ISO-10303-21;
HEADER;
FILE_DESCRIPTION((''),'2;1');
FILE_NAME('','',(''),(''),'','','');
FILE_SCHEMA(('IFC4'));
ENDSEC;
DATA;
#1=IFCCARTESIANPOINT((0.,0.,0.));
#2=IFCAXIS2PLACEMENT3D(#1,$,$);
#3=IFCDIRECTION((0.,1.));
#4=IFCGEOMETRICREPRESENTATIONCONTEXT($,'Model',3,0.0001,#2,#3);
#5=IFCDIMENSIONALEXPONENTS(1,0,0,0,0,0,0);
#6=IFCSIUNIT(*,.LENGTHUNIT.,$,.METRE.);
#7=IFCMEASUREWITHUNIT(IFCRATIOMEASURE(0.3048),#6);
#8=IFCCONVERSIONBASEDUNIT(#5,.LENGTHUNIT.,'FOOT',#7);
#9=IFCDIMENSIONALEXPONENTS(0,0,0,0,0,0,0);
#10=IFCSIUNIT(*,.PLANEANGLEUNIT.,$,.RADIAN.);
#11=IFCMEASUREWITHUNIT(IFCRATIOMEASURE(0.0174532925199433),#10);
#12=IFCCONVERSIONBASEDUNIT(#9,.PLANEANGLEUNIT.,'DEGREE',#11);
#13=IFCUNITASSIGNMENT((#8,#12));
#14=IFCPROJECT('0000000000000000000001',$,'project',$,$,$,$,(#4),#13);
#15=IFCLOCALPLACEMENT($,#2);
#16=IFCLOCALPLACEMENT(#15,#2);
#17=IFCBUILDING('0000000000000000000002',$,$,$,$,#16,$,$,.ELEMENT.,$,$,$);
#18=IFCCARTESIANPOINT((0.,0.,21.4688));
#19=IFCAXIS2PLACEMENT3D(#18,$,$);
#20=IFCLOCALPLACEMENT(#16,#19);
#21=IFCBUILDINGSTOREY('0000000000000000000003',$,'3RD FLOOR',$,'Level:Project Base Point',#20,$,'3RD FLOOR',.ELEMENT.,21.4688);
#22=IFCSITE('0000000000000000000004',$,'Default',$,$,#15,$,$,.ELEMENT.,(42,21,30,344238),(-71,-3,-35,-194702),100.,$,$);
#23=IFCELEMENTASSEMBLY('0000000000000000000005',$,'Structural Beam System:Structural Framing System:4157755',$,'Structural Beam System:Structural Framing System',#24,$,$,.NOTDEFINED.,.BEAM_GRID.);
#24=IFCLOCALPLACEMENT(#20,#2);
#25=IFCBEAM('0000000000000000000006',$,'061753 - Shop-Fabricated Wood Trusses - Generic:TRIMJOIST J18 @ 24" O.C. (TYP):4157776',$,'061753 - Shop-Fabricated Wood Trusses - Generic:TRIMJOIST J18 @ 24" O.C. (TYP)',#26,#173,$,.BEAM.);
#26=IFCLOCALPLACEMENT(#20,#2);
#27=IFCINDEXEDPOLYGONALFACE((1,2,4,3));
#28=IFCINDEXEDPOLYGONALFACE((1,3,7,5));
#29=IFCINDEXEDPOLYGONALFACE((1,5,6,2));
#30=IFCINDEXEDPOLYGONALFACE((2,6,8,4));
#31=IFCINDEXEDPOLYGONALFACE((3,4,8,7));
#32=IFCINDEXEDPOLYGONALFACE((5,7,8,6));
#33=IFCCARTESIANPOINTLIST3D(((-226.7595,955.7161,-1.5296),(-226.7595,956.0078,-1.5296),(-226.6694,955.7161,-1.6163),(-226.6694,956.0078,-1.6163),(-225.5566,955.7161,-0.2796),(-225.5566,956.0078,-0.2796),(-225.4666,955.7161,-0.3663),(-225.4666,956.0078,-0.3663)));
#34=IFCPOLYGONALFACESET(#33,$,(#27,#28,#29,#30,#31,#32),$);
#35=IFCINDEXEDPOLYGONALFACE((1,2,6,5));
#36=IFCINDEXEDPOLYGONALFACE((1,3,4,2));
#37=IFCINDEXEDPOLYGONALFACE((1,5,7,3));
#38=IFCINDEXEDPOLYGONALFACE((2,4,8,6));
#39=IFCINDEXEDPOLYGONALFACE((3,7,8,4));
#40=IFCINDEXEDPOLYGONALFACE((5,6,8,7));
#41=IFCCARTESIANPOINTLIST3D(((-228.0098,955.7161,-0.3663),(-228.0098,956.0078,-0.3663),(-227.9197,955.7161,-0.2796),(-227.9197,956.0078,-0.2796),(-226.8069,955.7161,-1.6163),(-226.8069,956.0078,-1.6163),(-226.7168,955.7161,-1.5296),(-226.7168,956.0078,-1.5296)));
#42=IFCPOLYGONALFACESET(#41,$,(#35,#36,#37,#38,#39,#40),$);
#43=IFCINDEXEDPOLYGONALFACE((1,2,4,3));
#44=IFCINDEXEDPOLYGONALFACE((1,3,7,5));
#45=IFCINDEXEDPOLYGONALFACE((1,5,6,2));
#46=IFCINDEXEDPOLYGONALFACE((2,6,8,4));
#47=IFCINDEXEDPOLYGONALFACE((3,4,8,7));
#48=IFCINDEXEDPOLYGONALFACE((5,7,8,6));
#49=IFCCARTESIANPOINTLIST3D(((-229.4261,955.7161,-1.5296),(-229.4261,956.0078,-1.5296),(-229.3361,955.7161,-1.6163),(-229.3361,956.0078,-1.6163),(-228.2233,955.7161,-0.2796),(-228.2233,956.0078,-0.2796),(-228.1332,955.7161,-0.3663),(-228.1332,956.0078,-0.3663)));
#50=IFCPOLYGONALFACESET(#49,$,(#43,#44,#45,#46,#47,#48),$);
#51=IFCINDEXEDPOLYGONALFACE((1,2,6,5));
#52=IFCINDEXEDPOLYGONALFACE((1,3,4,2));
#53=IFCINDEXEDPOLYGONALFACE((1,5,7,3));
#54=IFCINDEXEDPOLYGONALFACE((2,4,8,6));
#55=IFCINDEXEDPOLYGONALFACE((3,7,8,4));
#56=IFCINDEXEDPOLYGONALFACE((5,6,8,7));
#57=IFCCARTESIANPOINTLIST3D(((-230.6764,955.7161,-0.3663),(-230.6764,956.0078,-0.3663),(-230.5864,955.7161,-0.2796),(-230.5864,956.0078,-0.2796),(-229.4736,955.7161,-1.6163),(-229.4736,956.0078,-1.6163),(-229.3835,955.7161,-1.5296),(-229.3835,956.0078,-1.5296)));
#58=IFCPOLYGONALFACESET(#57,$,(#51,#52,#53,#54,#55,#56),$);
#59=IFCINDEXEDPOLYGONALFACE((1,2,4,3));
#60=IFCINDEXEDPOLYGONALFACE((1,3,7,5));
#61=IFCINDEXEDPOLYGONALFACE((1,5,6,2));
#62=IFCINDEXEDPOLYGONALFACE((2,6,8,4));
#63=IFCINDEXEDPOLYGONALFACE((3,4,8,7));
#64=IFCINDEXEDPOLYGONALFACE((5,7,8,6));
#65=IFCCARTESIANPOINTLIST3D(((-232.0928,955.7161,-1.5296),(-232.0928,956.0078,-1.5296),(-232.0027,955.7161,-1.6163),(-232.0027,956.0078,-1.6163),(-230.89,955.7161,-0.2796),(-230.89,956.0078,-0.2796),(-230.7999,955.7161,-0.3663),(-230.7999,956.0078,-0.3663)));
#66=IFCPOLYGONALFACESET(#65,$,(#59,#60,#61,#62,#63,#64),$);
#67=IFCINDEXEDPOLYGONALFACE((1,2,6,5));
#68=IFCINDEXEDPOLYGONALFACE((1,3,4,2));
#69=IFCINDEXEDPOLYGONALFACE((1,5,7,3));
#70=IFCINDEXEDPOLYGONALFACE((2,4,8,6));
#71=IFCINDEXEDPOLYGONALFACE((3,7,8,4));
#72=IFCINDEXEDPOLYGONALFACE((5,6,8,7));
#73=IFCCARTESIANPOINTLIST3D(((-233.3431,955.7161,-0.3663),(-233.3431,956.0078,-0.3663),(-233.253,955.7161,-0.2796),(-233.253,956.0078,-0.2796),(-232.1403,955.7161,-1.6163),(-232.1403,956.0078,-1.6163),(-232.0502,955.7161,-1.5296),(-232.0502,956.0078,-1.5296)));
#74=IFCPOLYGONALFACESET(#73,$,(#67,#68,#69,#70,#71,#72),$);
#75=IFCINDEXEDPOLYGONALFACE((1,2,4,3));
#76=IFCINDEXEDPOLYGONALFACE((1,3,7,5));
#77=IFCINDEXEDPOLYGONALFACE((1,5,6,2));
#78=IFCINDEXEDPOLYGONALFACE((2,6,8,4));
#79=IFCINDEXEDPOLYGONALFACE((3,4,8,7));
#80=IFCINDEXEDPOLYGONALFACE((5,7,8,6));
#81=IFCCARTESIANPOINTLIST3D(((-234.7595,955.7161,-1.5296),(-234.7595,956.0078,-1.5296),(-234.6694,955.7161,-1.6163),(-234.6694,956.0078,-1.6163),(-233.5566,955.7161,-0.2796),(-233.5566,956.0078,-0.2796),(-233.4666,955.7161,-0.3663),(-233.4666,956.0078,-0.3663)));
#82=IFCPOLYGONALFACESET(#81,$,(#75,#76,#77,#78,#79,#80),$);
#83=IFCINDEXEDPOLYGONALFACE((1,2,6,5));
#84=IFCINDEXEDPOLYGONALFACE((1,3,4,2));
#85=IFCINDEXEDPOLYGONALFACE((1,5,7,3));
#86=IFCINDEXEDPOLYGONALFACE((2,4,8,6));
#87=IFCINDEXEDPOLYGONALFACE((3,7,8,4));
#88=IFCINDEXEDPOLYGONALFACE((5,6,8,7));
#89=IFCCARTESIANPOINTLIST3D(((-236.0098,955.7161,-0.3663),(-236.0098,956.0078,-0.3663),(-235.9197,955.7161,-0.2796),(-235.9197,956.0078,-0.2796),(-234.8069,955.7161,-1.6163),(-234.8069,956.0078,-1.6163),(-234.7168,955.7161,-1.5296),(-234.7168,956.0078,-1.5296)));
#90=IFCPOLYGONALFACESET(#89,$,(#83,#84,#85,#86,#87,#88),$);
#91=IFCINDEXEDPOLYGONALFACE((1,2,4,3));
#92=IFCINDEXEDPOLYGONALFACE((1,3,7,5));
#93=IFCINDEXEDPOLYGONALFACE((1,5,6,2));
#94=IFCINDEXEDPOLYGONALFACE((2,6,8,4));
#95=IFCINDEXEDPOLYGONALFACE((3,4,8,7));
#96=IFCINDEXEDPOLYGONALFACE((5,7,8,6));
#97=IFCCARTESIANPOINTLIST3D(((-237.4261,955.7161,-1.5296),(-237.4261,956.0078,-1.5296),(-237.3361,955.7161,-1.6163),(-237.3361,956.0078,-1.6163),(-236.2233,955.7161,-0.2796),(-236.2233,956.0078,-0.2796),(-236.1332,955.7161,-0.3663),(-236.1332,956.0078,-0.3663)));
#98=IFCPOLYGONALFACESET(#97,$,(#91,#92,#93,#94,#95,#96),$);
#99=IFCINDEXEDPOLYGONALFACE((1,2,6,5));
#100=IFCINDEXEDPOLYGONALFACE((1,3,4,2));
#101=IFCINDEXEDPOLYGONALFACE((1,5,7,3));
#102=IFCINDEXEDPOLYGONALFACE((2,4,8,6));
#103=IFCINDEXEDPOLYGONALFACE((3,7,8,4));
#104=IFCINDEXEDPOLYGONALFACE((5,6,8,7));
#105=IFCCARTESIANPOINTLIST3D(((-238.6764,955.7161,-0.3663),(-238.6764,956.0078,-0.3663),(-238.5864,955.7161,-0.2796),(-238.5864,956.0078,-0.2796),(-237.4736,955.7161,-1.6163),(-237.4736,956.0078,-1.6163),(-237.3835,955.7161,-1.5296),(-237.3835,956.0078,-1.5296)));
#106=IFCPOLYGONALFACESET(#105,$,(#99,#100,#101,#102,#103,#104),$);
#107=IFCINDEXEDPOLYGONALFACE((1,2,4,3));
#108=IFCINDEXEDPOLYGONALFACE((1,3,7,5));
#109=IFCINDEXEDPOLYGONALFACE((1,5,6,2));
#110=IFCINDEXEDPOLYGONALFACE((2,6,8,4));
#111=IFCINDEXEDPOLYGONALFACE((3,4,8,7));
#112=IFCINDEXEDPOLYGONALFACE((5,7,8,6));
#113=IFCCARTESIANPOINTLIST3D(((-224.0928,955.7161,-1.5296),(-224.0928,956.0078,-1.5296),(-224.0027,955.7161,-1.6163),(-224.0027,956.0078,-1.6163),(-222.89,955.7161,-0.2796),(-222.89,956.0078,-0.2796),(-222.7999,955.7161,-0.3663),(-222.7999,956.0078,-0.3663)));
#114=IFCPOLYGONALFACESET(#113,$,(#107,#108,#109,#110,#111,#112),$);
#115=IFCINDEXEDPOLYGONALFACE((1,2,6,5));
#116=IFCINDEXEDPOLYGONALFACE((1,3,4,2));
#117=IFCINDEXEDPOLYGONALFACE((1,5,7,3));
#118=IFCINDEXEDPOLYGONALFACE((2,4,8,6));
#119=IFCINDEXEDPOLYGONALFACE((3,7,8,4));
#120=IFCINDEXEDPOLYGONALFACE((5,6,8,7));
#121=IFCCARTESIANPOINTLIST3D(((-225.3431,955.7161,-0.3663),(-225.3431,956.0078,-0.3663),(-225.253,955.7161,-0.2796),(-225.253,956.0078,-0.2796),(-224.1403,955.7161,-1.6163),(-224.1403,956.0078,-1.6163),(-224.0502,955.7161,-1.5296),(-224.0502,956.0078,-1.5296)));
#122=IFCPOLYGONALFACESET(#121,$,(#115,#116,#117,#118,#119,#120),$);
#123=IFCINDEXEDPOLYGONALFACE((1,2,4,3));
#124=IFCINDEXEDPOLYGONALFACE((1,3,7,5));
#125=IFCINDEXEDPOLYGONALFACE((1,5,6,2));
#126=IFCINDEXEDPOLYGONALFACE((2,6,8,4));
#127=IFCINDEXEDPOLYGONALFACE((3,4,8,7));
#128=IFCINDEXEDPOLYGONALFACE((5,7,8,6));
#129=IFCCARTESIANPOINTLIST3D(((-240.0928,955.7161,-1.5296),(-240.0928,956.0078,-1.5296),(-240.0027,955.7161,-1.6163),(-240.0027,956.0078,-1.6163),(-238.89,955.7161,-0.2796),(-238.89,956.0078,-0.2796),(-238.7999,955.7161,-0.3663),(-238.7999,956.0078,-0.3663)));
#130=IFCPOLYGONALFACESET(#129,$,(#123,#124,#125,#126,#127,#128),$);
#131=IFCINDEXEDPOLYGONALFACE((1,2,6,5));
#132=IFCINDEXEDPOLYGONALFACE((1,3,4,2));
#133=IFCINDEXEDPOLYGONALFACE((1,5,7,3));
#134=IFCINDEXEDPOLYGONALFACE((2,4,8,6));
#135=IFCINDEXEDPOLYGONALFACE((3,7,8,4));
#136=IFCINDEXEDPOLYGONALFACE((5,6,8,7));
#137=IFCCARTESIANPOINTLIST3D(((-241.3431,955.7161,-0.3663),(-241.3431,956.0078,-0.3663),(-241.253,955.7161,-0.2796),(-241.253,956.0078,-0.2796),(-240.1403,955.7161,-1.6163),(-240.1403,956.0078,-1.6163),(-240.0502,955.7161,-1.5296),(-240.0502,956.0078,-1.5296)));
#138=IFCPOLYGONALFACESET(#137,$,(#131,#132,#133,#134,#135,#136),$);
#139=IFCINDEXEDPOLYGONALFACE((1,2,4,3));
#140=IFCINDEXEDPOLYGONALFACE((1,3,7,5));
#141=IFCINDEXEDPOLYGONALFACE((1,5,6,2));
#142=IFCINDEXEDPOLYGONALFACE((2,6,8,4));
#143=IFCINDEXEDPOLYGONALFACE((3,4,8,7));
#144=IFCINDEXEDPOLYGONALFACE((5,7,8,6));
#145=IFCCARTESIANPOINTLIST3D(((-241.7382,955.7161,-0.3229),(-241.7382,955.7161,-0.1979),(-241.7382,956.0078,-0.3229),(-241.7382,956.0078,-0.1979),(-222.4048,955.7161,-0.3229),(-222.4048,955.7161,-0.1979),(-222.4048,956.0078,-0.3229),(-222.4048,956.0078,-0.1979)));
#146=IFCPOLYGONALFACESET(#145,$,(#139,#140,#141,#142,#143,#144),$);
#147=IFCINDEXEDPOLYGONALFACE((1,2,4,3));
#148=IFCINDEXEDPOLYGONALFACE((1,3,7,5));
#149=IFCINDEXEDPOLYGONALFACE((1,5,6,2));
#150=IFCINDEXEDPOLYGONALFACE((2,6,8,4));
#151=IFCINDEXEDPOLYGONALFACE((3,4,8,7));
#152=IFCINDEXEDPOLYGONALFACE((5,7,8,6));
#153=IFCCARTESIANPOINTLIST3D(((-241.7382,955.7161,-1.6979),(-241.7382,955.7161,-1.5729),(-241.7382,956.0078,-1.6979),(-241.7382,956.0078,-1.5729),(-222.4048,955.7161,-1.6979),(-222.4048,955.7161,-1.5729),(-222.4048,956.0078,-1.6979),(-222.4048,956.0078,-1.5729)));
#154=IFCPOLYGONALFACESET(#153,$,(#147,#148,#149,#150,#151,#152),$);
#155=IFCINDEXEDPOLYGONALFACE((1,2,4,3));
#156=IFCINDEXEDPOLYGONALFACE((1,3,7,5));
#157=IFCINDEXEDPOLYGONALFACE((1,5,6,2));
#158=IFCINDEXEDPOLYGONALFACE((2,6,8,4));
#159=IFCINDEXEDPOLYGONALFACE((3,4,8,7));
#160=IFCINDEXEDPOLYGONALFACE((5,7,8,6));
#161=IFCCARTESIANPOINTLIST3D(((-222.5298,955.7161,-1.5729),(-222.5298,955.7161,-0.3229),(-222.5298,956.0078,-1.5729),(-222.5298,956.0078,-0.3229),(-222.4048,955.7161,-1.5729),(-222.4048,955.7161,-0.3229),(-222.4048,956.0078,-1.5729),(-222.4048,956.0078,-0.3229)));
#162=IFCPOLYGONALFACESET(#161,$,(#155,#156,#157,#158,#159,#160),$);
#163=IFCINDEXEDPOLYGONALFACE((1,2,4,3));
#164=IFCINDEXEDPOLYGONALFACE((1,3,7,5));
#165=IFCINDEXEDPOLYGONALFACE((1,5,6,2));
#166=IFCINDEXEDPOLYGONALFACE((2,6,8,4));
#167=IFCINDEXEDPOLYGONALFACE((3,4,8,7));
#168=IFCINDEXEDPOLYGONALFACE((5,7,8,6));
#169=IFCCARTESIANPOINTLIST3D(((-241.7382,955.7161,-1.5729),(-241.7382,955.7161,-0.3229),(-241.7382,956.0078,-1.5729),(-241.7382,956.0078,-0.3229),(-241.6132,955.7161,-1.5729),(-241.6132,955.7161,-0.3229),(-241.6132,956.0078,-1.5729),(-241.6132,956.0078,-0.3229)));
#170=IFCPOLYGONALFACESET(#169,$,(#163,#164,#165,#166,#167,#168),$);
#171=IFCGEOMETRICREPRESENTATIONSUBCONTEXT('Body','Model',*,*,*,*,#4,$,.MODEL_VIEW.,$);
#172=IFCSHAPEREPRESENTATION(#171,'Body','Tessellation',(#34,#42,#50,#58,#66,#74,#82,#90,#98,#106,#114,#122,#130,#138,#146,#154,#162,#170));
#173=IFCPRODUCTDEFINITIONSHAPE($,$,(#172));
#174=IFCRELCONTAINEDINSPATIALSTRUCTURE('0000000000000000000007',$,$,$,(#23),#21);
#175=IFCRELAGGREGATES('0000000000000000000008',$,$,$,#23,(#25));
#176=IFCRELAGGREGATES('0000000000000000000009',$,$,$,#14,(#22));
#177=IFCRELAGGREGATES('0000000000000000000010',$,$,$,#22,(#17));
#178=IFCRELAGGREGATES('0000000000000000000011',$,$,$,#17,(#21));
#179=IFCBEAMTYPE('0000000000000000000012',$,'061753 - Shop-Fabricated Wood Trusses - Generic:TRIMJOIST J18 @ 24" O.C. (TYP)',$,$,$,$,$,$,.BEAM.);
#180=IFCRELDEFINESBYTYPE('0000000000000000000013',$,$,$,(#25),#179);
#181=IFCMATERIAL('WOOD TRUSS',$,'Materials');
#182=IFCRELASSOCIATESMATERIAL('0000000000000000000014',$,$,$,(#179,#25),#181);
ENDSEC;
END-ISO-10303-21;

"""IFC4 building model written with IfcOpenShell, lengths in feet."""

from ifc_helpers import new_model, entity, si_unit, converted_unit, direction, frame, frame_2d, origin, origin_2d_with_axis, place, context, subcontext, project, spatial, rectangle, extrude, source, transform, mapped, material, material_profile, profile_set, profile_usage, type_object, type_shapes, element, aggregate, save


model = new_model("IFC4")

# Units and contexts
model_context = context("Model", 3, precision=0.0001, world=origin(), true_north=direction((0.0, 1.0)))
body_context = subcontext(model_context, "Body", "Model", "MODEL_VIEW")
ifc_project = project(units=[converted_unit("LENGTHUNIT", "FOOT", entity("IfcRatioMeasure", 0.3048), si_unit("LENGTHUNIT", "METRE"), dimensions=[1, 0, 0, 0, 0, 0, 0]), converted_unit("PLANEANGLEUNIT", "DEGREE", entity("IfcRatioMeasure", 0.0174532925199433), si_unit("PLANEANGLEUNIT", "RADIAN"), dimensions=[0, 0, 0, 0, 0, 0, 0])], contexts=[model_context])

# Site, building, storey
site_placement = place(None, origin())
site = spatial("IfcSite", under=ifc_project, at=site_placement, Name="Default", CompositionType="ELEMENT", RefLatitude=(42, 21, 30, 344238), RefLongitude=(-71, -3, -35, -194702), RefElevation=100.0)
building_placement = place(site_placement, origin())
building = spatial("IfcBuilding", under=site, at=building_placement, CompositionType="ELEMENT")
storey_placement = place(building_placement, frame((0.0, 0.0, 21.4688)))
storey = spatial("IfcBuildingStorey", under=building, at=storey_placement, Name="3RD FLOOR", ObjectType="Level:Project Base Point", LongName="3RD FLOOR", CompositionType="ELEMENT", Elevation=21.4688)

# Element assembly, beam
assembly_1_placement = place(storey_placement, origin())
assembly_1 = element("IfcElementAssembly", 1, at=assembly_1_placement, inside=storey, Name="Structural Beam System:Structural Framing System:4157755", ObjectType="Structural Beam System:Structural Framing System", AssemblyPlace="NOTDEFINED", PredefinedType="BEAM_GRID")
ifc_material_1 = material(Name="WOOD TRUSS", Category="Materials")
ifc_material_profile_1 = material_profile(ifc_material_1, rectangle(XDim=1.7347, YDim=0.125, at=frame_2d((0.0, 0.0), x_axis=(1.0, 0.0))), Name="TRIMJOIST J18 @ 24\" O.C. (TYP)")
ifc_material_profile_2 = material_profile(ifc_material_1, rectangle(XDim=1.7347, YDim=0.125, at=frame_2d((0.0, 0.0), x_axis=(1.0, 0.0))), Name="TRIMJOIST J18 @ 24\" O.C. (TYP)")
ifc_material_profile_3 = material_profile(ifc_material_1, rectangle(XDim=1.7347, YDim=0.125, at=frame_2d((0.0, 0.0), x_axis=(1.0, 0.0))), Name="TRIMJOIST J18 @ 24\" O.C. (TYP)")
ifc_material_profile_4 = material_profile(ifc_material_1, rectangle(XDim=1.7347, YDim=0.125, at=frame_2d((0.0, 0.0), x_axis=(1.0, 0.0))), Name="TRIMJOIST J18 @ 24\" O.C. (TYP)")
ifc_material_profile_5 = material_profile(ifc_material_1, rectangle(XDim=1.7347, YDim=0.125, at=frame_2d((0.0, 0.0), x_axis=(1.0, 0.0))), Name="TRIMJOIST J18 @ 24\" O.C. (TYP)")
ifc_material_profile_6 = material_profile(ifc_material_1, rectangle(XDim=1.7347, YDim=0.125, at=frame_2d((0.0, 0.0), x_axis=(1.0, 0.0))), Name="TRIMJOIST J18 @ 24\" O.C. (TYP)")
ifc_material_profile_7 = material_profile(ifc_material_1, rectangle(XDim=1.7347, YDim=0.125, at=frame_2d((0.0, 0.0), x_axis=(1.0, 0.0))), Name="TRIMJOIST J18 @ 24\" O.C. (TYP)")
ifc_material_profile_8 = material_profile(ifc_material_1, rectangle(XDim=1.7347, YDim=0.125, at=frame_2d((0.0, 0.0), x_axis=(1.0, 0.0))), Name="TRIMJOIST J18 @ 24\" O.C. (TYP)")
ifc_material_profile_9 = material_profile(ifc_material_1, rectangle(XDim=1.7347, YDim=0.125, at=frame_2d((0.0, 0.0), x_axis=(1.0, 0.0))), Name="TRIMJOIST J18 @ 24\" O.C. (TYP)")
ifc_material_profile_10 = material_profile(ifc_material_1, rectangle(XDim=1.7347, YDim=0.125, at=origin_2d_with_axis()), Name="TRIMJOIST J18 @ 24\" O.C. (TYP)")
ifc_material_profile_11 = material_profile(ifc_material_1, rectangle(XDim=0.125, YDim=0.2917, at=origin_2d_with_axis()), Name="TRIMJOIST J18 @ 24\" O.C. (TYP)")
ifc_material_profile_12 = material_profile(ifc_material_1, rectangle(XDim=0.125, YDim=0.2917, at=origin_2d_with_axis()), Name="TRIMJOIST J18 @ 24\" O.C. (TYP)")
ifc_material_profile_13 = material_profile(ifc_material_1, rectangle(XDim=1.25, YDim=0.2917, at=origin_2d_with_axis()), Name="TRIMJOIST J18 @ 24\" O.C. (TYP)")
ifc_material_profile_14 = material_profile(ifc_material_1, rectangle(XDim=1.25, YDim=0.2917, at=origin_2d_with_axis()), Name="TRIMJOIST J18 @ 24\" O.C. (TYP)")
ifc_profile_set_1 = profile_set([ifc_material_profile_1, ifc_material_profile_2, ifc_material_profile_3, ifc_material_profile_4, ifc_material_profile_5, ifc_material_profile_6, ifc_material_profile_7, ifc_material_profile_8, ifc_material_profile_9, ifc_material_profile_10, ifc_material_profile_11, ifc_material_profile_12, ifc_material_profile_13, ifc_material_profile_14], Name="TRIMJOIST J18 @ 24\" O.C. (TYP)")
ifc_profile_usage_1 = profile_usage(ifc_profile_set_1, cardinal=8)
beam_type_1 = type_object("IfcBeamType", Name="061753 - Shop-Fabricated Wood Trusses - Generic:TRIMJOIST J18 @ 24\" O.C. (TYP)", PredefinedType="BEAM", material=ifc_profile_set_1)
shared_shape_1 = source(origin(), body_context, "Body", "SweptSolid", [
    extrude(rectangle(XDim=1.7347, YDim=0.125, at=frame_2d((0.0, 0.0), x_axis=(1.0, 0.0))), frame((5.9585, -0.1458, 0.0), z_axis=(0.0, 1.0, 0.0), x_axis=(0.693383, 0.0, 0.720569)), (0.0, 0.0, 1.0), 0.2917),
    extrude(rectangle(XDim=1.7347, YDim=0.125, at=origin_2d_with_axis()), frame((4.7082, -0.1458, 0.0), z_axis=(0.0, 1.0, 0.0), x_axis=(0.693383, 0.0, -0.720569)), (0.0, 0.0, 1.0), 0.2917),
    extrude(rectangle(XDim=1.7347, YDim=0.125, at=frame_2d((0.0, 0.0), x_axis=(1.0, 0.0))), frame((3.2918, -0.1458, 0.0), z_axis=(0.0, 1.0, 0.0), x_axis=(0.693383, 0.0, 0.720569)), (0.0, 0.0, 1.0), 0.2917),
    extrude(rectangle(XDim=1.7347, YDim=0.125, at=frame_2d((0.0, 0.0), x_axis=(1.0, 0.0))), frame((2.0415, -0.1458, 0.0), z_axis=(0.0, 1.0, 0.0), x_axis=(0.693383, 0.0, -0.720569)), (0.0, 0.0, 1.0), 0.2917),
    extrude(rectangle(XDim=1.7347, YDim=0.125, at=frame_2d((0.0, 0.0), x_axis=(1.0, 0.0))), frame((0.6251, -0.1458, 0.0), z_axis=(0.0, 1.0, 0.0), x_axis=(0.693383, 0.0, 0.720569)), (0.0, 0.0, 1.0), 0.2917),
    extrude(rectangle(XDim=1.7347, YDim=0.125, at=frame_2d((0.0, 0.0), x_axis=(1.0, 0.0))), frame((-0.6251, -0.1458, 0.0), z_axis=(0.0, 1.0, 0.0), x_axis=(0.693383, 0.0, -0.720569)), (0.0, 0.0, 1.0), 0.2917),
    extrude(rectangle(XDim=1.7347, YDim=0.125, at=frame_2d((0.0, 0.0), x_axis=(1.0, 0.0))), frame((-2.0415, -0.1458, 0.0), z_axis=(0.0, 1.0, 0.0), x_axis=(0.693383, 0.0, 0.720569)), (0.0, 0.0, 1.0), 0.2917),
    extrude(rectangle(XDim=1.7347, YDim=0.125, at=origin_2d_with_axis()), frame((-3.2918, -0.1458, 0.0), z_axis=(0.0, 1.0, 0.0), x_axis=(0.693383, 0.0, -0.720569)), (0.0, 0.0, 1.0), 0.2917),
    extrude(rectangle(XDim=1.7347, YDim=0.125, at=frame_2d((0.0, 0.0), x_axis=(1.0, 0.0))), frame((-4.7082, -0.1458, 0.0), z_axis=(0.0, 1.0, 0.0), x_axis=(0.693383, 0.0, 0.720569)), (0.0, 0.0, 1.0), 0.2917),
    extrude(rectangle(XDim=1.7347, YDim=0.125, at=frame_2d((0.0, 0.0), x_axis=(1.0, 0.0))), frame((-5.9585, -0.1458, 0.0), z_axis=(0.0, 1.0, 0.0), x_axis=(0.693383, 0.0, -0.720569)), (0.0, 0.0, 1.0), 0.2917),
    extrude(rectangle(XDim=1.7347, YDim=0.125, at=frame_2d((0.0, 0.0), x_axis=(1.0, 0.0))), frame((8.6251, -0.1458, 0.0), z_axis=(0.0, 1.0, 0.0), x_axis=(0.693383, 0.0, 0.720569)), (0.0, 0.0, 1.0), 0.2917),
    extrude(rectangle(XDim=1.7347, YDim=0.125, at=origin_2d_with_axis()), frame((7.3749, -0.1458, 0.0), z_axis=(0.0, 1.0, 0.0), x_axis=(0.693383, 0.0, -0.720569)), (0.0, 0.0, 1.0), 0.2917),
    extrude(rectangle(XDim=1.7347, YDim=0.125, at=frame_2d((0.0, 0.0), x_axis=(1.0, 0.0))), frame((-7.3749, -0.1458, 0.0), z_axis=(0.0, 1.0, 0.0), x_axis=(0.693383, 0.0, 0.720569)), (0.0, 0.0, 1.0), 0.2917),
    extrude(rectangle(XDim=1.7347, YDim=0.125, at=origin_2d_with_axis()), frame((-8.6251, -0.1458, 0.0), z_axis=(0.0, 1.0, 0.0), x_axis=(0.693383, 0.0, -0.720569)), (0.0, 0.0, 1.0), 0.2917),
    extrude(rectangle(XDim=0.125, YDim=0.2917, at=origin_2d_with_axis()), frame((-9.6667, 0.0, 0.6875), z_axis=(1.0, 0.0, 0.0), x_axis=(0.0, 0.0, -1.0)), (0.0, 0.0, 1.0), 19.3333),
    extrude(rectangle(XDim=0.125, YDim=0.2917, at=origin_2d_with_axis()), frame((-9.6667, 0.0, -0.6875), z_axis=(1.0, 0.0, 0.0), x_axis=(0.0, 0.0, -1.0)), (0.0, 0.0, 1.0), 19.3333),
    extrude(rectangle(XDim=1.25, YDim=0.2917, at=origin_2d_with_axis()), frame((9.5417, 0.0, 0.0), z_axis=(1.0, 0.0, 0.0), x_axis=(0.0, 0.0, -1.0)), (0.0, 0.0, 1.0), 0.125),
    extrude(rectangle(XDim=1.25, YDim=0.2917, at=origin_2d_with_axis()), frame((-9.6667, 0.0, 0.0), z_axis=(1.0, 0.0, 0.0), x_axis=(0.0, 0.0, -1.0)), (0.0, 0.0, 1.0), 0.125),
])
type_shapes(beam_type_1, [shared_shape_1])
beam_1_placement = place(assembly_1_placement, frame((-232.0715, 955.8619, -0.9479)))
beam_1 = element("IfcBeam", 2, at=beam_1_placement, type_object=beam_type_1, material=ifc_profile_usage_1, Name="061753 - Shop-Fabricated Wood Trusses - Generic:TRIMJOIST J18 @ 24\" O.C. (TYP):4157776", ObjectType="061753 - Shop-Fabricated Wood Trusses - Generic:TRIMJOIST J18 @ 24\" O.C. (TYP)", PredefinedType="BEAM", context=body_context, shape_type="MappedRepresentation", body=[
    mapped(shared_shape_1, transform((0.0, 0.0, 0.0), scale=1.0)),
])
aggregate(assembly_1, [beam_1])

save(model, "model.ifc")
